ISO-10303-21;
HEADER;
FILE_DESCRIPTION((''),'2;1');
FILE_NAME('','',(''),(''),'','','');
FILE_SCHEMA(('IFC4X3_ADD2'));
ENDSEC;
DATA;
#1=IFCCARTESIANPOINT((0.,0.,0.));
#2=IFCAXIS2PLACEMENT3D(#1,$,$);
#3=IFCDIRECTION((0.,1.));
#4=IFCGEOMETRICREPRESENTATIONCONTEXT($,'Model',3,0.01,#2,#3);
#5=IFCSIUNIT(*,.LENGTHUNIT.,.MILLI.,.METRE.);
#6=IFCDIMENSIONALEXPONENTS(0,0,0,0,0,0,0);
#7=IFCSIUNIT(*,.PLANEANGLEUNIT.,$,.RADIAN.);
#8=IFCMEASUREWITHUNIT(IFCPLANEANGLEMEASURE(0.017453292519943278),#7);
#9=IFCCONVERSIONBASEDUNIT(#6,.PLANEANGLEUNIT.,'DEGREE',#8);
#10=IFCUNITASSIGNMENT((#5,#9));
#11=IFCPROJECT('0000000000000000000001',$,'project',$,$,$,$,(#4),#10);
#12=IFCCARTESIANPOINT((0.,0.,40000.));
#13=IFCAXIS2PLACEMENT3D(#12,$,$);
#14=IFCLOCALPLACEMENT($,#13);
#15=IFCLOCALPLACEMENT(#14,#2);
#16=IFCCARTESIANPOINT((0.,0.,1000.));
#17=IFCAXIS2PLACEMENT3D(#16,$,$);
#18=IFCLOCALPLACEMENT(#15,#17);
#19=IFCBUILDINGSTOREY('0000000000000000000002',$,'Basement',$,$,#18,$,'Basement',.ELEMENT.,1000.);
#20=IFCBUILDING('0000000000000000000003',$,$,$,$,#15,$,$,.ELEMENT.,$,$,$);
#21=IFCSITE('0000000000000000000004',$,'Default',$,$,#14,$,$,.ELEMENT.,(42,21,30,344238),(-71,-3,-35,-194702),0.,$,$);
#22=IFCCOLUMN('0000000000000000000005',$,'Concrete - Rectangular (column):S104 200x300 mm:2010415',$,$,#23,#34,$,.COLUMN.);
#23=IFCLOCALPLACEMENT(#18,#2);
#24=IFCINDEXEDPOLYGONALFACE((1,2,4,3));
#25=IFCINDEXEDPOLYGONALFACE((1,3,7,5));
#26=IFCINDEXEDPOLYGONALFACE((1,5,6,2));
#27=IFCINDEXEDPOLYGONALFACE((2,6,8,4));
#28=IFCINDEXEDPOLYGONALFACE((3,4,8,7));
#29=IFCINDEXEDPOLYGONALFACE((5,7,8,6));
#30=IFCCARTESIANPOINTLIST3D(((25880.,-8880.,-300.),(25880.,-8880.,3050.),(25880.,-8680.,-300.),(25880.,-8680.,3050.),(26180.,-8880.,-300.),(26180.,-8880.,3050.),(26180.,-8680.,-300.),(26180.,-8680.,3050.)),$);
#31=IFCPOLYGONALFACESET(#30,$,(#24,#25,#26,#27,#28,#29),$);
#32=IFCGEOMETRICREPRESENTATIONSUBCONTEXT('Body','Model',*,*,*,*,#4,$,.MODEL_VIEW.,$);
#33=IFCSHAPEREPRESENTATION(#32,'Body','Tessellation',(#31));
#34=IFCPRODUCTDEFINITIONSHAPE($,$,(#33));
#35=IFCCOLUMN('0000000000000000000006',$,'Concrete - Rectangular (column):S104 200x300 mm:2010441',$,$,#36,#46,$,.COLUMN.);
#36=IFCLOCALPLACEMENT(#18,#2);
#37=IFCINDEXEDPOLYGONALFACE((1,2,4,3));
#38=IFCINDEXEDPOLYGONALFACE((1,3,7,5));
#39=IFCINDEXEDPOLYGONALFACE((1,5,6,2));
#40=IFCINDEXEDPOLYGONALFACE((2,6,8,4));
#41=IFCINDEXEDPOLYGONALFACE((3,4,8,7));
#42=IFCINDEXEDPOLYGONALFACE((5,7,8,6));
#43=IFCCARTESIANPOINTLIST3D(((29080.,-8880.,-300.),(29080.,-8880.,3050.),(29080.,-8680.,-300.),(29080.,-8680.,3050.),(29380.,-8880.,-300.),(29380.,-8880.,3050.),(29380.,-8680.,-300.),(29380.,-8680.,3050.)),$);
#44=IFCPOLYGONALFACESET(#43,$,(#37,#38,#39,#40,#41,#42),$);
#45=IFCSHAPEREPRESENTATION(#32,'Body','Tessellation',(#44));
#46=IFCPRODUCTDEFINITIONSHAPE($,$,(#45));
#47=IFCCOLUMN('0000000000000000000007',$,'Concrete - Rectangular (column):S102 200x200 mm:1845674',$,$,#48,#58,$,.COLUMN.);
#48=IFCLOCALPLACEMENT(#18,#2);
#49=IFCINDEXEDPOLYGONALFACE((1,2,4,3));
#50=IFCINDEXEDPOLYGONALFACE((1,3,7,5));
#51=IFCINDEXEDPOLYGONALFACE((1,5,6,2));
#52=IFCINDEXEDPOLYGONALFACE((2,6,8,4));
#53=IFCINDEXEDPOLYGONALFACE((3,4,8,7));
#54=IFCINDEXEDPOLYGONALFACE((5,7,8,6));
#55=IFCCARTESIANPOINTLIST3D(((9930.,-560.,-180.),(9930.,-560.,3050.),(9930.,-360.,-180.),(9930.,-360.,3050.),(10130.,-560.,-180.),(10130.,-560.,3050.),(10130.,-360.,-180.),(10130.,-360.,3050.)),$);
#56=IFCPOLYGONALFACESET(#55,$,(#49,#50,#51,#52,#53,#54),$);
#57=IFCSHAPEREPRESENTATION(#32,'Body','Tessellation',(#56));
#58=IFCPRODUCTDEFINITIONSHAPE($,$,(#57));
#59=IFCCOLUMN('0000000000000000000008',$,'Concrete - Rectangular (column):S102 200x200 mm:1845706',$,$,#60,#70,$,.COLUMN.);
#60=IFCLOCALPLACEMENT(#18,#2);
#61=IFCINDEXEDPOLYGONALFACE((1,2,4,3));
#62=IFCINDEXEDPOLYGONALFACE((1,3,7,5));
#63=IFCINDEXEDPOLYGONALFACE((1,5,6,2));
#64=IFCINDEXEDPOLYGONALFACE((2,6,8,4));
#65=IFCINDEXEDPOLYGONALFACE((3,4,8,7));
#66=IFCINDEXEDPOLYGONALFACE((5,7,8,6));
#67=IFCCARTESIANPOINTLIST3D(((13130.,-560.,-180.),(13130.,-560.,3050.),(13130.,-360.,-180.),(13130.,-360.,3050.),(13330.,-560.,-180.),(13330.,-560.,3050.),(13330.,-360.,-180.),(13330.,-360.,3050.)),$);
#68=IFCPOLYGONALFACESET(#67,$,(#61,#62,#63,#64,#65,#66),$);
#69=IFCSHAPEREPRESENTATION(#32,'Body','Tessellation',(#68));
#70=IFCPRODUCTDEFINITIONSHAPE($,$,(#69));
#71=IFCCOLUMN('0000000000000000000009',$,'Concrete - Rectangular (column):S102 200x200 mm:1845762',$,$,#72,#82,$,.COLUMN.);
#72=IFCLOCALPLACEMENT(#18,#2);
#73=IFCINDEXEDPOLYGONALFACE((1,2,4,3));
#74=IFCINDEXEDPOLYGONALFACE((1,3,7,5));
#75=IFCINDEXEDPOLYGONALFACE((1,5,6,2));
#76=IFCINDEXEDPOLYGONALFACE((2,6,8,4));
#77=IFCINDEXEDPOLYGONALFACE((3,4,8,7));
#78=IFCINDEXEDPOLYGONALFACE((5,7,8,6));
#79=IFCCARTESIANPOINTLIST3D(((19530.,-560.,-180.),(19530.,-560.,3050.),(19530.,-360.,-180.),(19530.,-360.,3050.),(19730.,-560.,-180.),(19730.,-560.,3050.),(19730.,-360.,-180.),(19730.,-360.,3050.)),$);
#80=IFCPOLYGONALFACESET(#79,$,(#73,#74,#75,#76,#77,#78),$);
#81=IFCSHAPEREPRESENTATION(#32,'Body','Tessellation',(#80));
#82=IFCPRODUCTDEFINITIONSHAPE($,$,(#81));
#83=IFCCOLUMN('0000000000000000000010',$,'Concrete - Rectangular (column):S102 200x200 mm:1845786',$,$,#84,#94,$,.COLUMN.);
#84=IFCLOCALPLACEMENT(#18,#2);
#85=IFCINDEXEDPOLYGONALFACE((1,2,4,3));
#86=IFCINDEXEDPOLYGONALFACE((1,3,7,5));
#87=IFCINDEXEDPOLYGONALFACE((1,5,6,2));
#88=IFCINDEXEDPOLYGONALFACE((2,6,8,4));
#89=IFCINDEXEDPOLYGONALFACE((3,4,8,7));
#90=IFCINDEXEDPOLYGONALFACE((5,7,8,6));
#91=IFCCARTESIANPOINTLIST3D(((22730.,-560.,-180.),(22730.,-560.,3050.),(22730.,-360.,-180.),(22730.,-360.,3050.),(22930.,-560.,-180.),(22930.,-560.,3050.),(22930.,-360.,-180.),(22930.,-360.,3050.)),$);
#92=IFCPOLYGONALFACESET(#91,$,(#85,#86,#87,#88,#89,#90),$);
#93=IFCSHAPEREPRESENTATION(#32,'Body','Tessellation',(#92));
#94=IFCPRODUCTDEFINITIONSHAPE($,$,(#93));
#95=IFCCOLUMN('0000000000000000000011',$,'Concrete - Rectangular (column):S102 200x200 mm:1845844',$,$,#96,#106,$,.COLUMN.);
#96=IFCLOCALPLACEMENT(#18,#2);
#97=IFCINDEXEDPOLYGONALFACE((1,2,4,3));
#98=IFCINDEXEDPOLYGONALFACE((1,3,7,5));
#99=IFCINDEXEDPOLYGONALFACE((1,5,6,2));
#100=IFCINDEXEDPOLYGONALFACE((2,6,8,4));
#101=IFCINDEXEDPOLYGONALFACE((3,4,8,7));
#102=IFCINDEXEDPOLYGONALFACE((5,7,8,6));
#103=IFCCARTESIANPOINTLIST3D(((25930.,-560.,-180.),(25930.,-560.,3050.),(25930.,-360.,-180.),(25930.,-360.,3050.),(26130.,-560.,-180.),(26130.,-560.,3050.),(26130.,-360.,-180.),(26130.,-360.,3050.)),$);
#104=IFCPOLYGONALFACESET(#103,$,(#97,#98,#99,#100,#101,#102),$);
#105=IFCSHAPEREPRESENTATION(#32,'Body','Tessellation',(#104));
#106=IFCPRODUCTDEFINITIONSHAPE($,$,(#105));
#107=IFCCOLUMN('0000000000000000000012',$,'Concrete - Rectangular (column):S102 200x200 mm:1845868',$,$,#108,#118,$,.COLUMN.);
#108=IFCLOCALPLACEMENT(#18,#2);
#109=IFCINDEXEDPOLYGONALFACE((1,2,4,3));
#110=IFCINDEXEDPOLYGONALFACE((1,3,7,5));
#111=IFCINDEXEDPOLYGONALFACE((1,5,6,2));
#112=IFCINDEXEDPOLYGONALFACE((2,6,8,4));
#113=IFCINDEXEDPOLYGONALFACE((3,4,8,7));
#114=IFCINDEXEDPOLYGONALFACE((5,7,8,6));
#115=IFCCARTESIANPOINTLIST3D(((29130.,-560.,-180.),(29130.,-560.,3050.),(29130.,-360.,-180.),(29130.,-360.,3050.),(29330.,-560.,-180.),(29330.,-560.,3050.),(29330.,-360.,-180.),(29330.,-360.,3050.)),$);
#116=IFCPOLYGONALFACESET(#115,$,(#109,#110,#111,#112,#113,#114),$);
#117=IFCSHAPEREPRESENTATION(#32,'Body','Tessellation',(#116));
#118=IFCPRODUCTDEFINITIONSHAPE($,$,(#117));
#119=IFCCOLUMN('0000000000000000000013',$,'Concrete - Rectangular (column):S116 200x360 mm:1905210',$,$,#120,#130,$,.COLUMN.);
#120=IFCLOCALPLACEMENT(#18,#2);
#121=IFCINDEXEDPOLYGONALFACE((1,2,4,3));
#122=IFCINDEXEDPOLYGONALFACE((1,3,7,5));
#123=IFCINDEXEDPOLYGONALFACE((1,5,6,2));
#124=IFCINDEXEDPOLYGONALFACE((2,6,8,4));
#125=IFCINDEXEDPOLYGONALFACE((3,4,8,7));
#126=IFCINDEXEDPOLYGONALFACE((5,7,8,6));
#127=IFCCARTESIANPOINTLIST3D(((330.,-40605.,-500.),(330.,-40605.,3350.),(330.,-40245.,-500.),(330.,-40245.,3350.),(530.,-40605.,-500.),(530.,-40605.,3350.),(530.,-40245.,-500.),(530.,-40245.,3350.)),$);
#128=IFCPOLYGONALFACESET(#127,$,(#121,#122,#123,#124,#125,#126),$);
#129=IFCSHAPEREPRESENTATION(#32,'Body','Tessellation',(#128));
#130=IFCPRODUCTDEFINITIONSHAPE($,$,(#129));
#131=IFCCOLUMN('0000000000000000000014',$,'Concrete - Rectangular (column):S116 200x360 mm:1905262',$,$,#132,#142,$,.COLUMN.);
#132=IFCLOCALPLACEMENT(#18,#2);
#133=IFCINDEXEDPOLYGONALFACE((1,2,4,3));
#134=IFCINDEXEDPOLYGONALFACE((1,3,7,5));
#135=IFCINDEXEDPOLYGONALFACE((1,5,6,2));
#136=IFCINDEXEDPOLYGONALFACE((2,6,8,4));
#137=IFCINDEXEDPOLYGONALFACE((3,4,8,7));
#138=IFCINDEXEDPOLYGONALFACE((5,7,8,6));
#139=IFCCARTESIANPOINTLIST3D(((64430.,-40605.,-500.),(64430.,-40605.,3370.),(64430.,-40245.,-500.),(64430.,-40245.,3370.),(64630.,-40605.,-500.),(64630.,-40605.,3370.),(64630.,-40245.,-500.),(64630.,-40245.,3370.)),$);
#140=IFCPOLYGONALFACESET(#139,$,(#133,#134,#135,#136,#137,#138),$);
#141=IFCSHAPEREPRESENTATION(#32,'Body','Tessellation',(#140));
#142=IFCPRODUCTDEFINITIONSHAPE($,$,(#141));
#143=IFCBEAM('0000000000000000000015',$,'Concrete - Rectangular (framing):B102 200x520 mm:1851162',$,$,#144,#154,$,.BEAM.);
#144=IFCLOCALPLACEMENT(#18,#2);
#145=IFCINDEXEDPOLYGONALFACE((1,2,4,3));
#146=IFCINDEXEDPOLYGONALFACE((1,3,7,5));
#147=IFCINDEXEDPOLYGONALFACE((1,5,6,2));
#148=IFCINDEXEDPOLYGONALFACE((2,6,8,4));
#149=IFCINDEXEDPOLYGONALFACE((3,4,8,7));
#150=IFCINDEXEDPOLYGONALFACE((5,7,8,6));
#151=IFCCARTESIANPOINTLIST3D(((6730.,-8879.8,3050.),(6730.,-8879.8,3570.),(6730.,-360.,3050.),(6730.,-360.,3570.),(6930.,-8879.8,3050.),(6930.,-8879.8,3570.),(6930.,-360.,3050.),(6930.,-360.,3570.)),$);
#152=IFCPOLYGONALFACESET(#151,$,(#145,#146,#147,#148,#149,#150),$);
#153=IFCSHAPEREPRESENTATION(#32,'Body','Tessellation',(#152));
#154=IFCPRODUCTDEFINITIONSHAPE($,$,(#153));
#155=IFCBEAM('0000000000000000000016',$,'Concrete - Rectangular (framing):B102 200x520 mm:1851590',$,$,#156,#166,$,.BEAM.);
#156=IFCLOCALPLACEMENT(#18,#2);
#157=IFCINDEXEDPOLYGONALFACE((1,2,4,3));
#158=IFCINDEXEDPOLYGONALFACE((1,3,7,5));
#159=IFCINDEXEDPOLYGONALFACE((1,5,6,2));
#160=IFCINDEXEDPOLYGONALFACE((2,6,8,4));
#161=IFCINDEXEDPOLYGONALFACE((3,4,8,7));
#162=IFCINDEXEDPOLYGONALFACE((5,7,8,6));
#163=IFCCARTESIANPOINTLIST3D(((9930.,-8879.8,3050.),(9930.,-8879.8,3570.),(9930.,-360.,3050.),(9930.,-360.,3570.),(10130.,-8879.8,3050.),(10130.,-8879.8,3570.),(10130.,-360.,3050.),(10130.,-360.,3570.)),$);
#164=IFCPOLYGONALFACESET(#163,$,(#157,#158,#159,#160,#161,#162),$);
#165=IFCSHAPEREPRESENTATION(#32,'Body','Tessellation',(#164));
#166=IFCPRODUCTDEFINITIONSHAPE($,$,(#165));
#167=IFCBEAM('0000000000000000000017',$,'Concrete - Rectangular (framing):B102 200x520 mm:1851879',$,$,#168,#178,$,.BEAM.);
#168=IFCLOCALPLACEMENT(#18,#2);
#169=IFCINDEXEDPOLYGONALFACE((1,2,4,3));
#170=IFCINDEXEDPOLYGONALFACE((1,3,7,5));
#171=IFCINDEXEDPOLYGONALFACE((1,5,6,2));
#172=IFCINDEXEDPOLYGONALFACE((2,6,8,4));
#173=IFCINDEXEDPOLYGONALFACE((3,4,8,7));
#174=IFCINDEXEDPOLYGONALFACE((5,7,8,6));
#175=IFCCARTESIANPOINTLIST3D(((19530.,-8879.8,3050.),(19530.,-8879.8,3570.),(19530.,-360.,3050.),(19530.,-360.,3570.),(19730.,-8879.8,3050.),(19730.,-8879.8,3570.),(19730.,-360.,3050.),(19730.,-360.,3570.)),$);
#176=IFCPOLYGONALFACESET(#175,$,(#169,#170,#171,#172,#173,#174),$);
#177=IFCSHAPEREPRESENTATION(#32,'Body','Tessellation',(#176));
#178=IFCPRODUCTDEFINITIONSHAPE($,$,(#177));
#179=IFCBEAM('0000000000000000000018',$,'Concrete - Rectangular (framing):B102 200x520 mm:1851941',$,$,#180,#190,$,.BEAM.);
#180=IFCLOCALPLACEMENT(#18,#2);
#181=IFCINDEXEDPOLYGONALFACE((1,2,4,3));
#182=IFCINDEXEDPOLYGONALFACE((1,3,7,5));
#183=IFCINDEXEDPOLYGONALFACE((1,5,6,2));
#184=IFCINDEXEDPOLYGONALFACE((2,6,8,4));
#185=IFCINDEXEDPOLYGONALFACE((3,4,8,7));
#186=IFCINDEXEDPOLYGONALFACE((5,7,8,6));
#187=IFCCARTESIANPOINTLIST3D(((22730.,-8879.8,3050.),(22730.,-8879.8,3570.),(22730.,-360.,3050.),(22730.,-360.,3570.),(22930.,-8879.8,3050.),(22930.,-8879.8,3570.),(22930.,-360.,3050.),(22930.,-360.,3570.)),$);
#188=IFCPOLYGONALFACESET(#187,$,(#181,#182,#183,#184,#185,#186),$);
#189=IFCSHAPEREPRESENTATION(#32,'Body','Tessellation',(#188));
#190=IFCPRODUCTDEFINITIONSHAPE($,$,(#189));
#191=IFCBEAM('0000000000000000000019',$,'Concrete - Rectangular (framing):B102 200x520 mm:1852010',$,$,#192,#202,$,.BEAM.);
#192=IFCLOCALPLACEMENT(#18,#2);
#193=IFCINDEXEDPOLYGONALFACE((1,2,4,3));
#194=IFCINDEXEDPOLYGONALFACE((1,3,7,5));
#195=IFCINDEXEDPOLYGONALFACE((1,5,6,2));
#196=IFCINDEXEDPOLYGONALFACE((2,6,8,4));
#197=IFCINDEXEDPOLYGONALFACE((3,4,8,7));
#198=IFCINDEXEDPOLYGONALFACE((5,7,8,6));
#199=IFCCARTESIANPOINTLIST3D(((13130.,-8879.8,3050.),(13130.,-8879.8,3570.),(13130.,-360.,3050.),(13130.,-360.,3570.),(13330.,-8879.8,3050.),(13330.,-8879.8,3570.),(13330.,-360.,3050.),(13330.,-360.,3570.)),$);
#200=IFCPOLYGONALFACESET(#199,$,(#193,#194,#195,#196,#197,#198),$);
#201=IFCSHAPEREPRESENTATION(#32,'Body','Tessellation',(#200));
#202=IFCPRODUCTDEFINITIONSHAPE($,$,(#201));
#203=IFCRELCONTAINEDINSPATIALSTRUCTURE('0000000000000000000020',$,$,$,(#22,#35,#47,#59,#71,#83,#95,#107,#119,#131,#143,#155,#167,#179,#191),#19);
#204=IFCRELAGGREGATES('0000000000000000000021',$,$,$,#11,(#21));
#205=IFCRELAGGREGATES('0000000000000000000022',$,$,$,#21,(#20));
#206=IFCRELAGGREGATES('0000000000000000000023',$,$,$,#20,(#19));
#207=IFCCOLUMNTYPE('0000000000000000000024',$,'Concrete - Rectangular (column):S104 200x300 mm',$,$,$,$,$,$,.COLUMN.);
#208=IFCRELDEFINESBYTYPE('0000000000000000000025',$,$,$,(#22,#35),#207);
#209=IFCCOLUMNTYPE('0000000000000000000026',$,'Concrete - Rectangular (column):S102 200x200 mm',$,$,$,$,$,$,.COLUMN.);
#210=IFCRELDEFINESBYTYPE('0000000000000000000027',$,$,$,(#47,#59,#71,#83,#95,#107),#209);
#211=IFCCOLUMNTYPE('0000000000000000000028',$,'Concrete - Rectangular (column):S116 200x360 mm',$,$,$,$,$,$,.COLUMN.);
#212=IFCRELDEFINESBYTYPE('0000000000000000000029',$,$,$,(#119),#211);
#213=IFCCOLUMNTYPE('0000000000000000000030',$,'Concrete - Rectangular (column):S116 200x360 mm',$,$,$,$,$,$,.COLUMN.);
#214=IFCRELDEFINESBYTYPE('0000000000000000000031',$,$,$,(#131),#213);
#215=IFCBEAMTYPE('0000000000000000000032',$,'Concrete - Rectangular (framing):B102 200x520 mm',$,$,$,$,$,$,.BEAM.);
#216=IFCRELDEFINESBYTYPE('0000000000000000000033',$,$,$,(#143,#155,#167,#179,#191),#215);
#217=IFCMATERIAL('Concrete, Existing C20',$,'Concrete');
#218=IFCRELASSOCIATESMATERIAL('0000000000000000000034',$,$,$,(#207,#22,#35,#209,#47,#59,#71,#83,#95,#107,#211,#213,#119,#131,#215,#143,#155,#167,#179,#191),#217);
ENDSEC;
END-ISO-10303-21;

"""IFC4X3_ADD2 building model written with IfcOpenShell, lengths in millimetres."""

from ifc_helpers import new_model, entity, si_unit, converted_unit, direction, frame, frame_2d, origin, origin_2d_with_axis, place, context, subcontext, project, spatial, rectangle, extrude, source, transform, mapped, material, material_profile, profile_set, profile_usage, type_object, type_shapes, element, save


model = new_model("IFC4X3_ADD2")

# Units and contexts
model_context = context("Model", 3, precision=0.01, world=origin(), true_north=direction((0.0, 1.0)))
body_context = subcontext(model_context, "Body", "Model", "MODEL_VIEW")
ifc_project = project(units=[si_unit("LENGTHUNIT", "METRE", prefix="MILLI"), converted_unit("PLANEANGLEUNIT", "DEGREE", entity("IfcPlaneAngleMeasure", 0.017453292519943278), si_unit("PLANEANGLEUNIT", "RADIAN"), dimensions=[0, 0, 0, 0, 0, 0, 0])], contexts=[model_context])

# Site, building, storey
site_placement = place(None, frame((0.0, 0.0, 40000.0)))
site = spatial("IfcSite", under=ifc_project, at=site_placement, Name="Default", CompositionType="ELEMENT", RefLatitude=(42, 21, 30, 344238), RefLongitude=(-71, -3, -35, -194702), RefElevation=0.0)
building_placement = place(site_placement, origin())
building = spatial("IfcBuilding", under=site, at=building_placement, CompositionType="ELEMENT")
storey_placement = place(building_placement, frame((0.0, 0.0, 1000.0)))
storey = spatial("IfcBuildingStorey", under=building, at=storey_placement, Name="Basement", LongName="Basement", CompositionType="ELEMENT", Elevation=1000.0)

# Columns
ifc_material_1 = material(Name="Concrete, Existing C20", Category="Concrete")
ifc_material_profile_1 = material_profile(ifc_material_1, rectangle(XDim=200.0, YDim=300.0, at=frame_2d((0.0, 0.0), x_axis=(1.0, 0.0))), Name="S104 200x300 mm")
ifc_profile_set_1 = profile_set([ifc_material_profile_1], Name="S104 200x300 mm")
ifc_profile_usage_1 = profile_usage(ifc_profile_set_1)
column_type_1 = type_object("IfcColumnType", Name="Concrete - Rectangular (column):S104 200x300 mm", PredefinedType="COLUMN", material=ifc_profile_set_1)
shared_shape_1 = source(origin(), body_context, "Body", "SweptSolid", [
    extrude(rectangle(XDim=200.0, YDim=300.0, at=origin_2d_with_axis()), frame((0.0, 0.0, 700.0), z_axis=(0.0, 0.0, 1.0), x_axis=(-1.0, 0.0, 0.0)), (0.0, 0.0, 1.0), 3350.0),
])
type_shapes(column_type_1, [shared_shape_1])
for number, where, z_axis, x_axis, name in (
    (1, (26030.0, -8780.0, -1000.0), (0.0, 0.0, 1.0), (0.0, -1.0, 0.0), "Concrete - Rectangular (column):S104 200x300 mm:2010415"),
    (2, (29230.0, -8780.0, -1000.0), (0.0, 0.0, 1.0), (0.0, -1.0, 0.0), "Concrete - Rectangular (column):S104 200x300 mm:2010441"),
):
    element("IfcColumn", number, at=place(storey_placement, frame(where, z_axis=z_axis, x_axis=x_axis)), inside=storey, type_object=column_type_1, material=ifc_profile_usage_1, Name=name, PredefinedType="COLUMN", context=body_context, shape_type="MappedRepresentation", body=[
        mapped(shared_shape_1, transform((0.0, 0.0, 0.0), scale=1.0)),
    ])
ifc_material_profile_2 = material_profile(ifc_material_1, rectangle(XDim=200.0, YDim=200.0, at=frame_2d((0.0, 0.0), x_axis=(1.0, 0.0))), Name="S102 200x200 mm")
ifc_profile_set_2 = profile_set([ifc_material_profile_2], Name="S102 200x200 mm")
ifc_profile_usage_2 = profile_usage(ifc_profile_set_2)
column_type_2 = type_object("IfcColumnType", Name="Concrete - Rectangular (column):S102 200x200 mm", PredefinedType="COLUMN", material=ifc_profile_set_2)
shared_shape_2 = source(origin(), body_context, "Body", "SweptSolid", [
    extrude(rectangle(XDim=200.0, YDim=200.0, at=origin_2d_with_axis()), frame((0.0, 0.0, 820.0), z_axis=(0.0, 0.0, 1.0), x_axis=(-1.0, 0.0, 0.0)), (0.0, 0.0, 1.0), 3230.0),
])
type_shapes(column_type_2, [shared_shape_2])
for number, where, z_axis, x_axis, name in (
    (3, (10030.0, -460.0, -1000.0), (0.0, 0.0, 1.0), (0.0, -1.0, 0.0), "Concrete - Rectangular (column):S102 200x200 mm:1845674"),
    (4, (13230.0, -460.0, -1000.0), (0.0, 0.0, 1.0), (0.0, -1.0, 0.0), "Concrete - Rectangular (column):S102 200x200 mm:1845706"),
    (5, (19630.0, -460.0, -1000.0), (0.0, 0.0, 1.0), (0.0, -1.0, 0.0), "Concrete - Rectangular (column):S102 200x200 mm:1845762"),
    (6, (22830.0, -460.0, -1000.0), (0.0, 0.0, 1.0), (0.0, -1.0, 0.0), "Concrete - Rectangular (column):S102 200x200 mm:1845786"),
    (7, (26030.0, -460.0, -1000.0), (0.0, 0.0, 1.0), (0.0, -1.0, 0.0), "Concrete - Rectangular (column):S102 200x200 mm:1845844"),
    (8, (29230.0, -460.0, -1000.0), (0.0, 0.0, 1.0), (0.0, -1.0, 0.0), "Concrete - Rectangular (column):S102 200x200 mm:1845868"),
):
    element("IfcColumn", number, at=place(storey_placement, frame(where, z_axis=z_axis, x_axis=x_axis)), inside=storey, type_object=column_type_2, material=ifc_profile_usage_2, Name=name, PredefinedType="COLUMN", context=body_context, shape_type="MappedRepresentation", body=[
        mapped(shared_shape_2, transform((0.0, 0.0, 0.0), scale=1.0)),
    ])
ifc_material_profile_3 = material_profile(ifc_material_1, rectangle(XDim=360.0, YDim=200.0, at=origin_2d_with_axis()), Name="S116 200x360 mm")
ifc_profile_set_3 = profile_set([ifc_material_profile_3], Name="S116 200x360 mm")
ifc_profile_usage_3 = profile_usage(ifc_profile_set_3)
column_type_3 = type_object("IfcColumnType", Name="Concrete - Rectangular (column):S116 200x360 mm", PredefinedType="COLUMN", material=ifc_profile_set_3)
shared_shape_3 = source(origin(), body_context, "Body", "SweptSolid", [
    extrude(rectangle(XDim=360.0, YDim=200.0, at=frame_2d((0.0, 0.0), x_axis=(1.0, 0.0))), frame((430.0, -40425.0, 500.0), z_axis=(0.0, 0.0, 1.0), x_axis=(0.0, -1.0, 0.0)), (0.0, 0.0, 1.0), 3850.0),
])
type_shapes(column_type_3, [shared_shape_3])
column_1_placement = place(storey_placement, frame((0.0, 0.0, -1000.0)))
element("IfcColumn", 9, at=column_1_placement, inside=storey, type_object=column_type_3, material=ifc_profile_usage_3, Name="Concrete - Rectangular (column):S116 200x360 mm:1905210", PredefinedType="COLUMN", context=body_context, shape_type="MappedRepresentation", body=[
    mapped(shared_shape_3, transform((0.0, 0.0, 0.0), scale=1.0)),
])
column_type_4 = type_object("IfcColumnType", Name="Concrete - Rectangular (column):S116 200x360 mm", PredefinedType="COLUMN", material=ifc_profile_set_3)
shared_shape_4 = source(origin(), body_context, "Body", "SweptSolid", [
    extrude(rectangle(XDim=360.0, YDim=200.0, at=frame_2d((0.0, 0.0), x_axis=(1.0, 0.0))), frame((64530.0, -40425.0, 500.0), z_axis=(0.0, 0.0, 1.0), x_axis=(0.0, 1.0, 0.0)), (0.0, 0.0, 1.0), 3870.0),
])
type_shapes(column_type_4, [shared_shape_4])
column_2_placement = place(storey_placement, frame((0.0, 0.0, -1000.0)))
element("IfcColumn", 10, at=column_2_placement, inside=storey, type_object=column_type_4, material=ifc_profile_usage_3, Name="Concrete - Rectangular (column):S116 200x360 mm:1905262", PredefinedType="COLUMN", context=body_context, shape_type="MappedRepresentation", body=[
    mapped(shared_shape_4, transform((0.0, 0.0, 0.0), scale=1.0)),
])

# Beams
ifc_material_profile_4 = material_profile(ifc_material_1, rectangle(XDim=8519.8, YDim=200.0, at=origin_2d_with_axis()), Name="B102 200x520 mm")
ifc_profile_set_4 = profile_set([ifc_material_profile_4], Name="B102 200x520 mm")
ifc_profile_usage_4 = profile_usage(ifc_profile_set_4, cardinal=8)
beam_type_1 = type_object("IfcBeamType", Name="Concrete - Rectangular (framing):B102 200x520 mm", PredefinedType="BEAM", material=ifc_profile_set_4)
shared_shape_5 = source(origin(), body_context, "Body", "SweptSolid", [
    extrude(rectangle(XDim=8519.8, YDim=200.0, at=origin_2d_with_axis()), frame((-0.1, 0.0, -260.0), z_axis=(0.0, 0.0, 1.0), x_axis=(-1.0, 0.0, 0.0)), (0.0, 0.0, 1.0), 520.0),
])
type_shapes(beam_type_1, [shared_shape_5])
for number, where, z_axis, x_axis, name in (
    (11, (6830.0, -4620.0, 3310.0), (0.0, 0.0, 1.0), (0.0, -1.0, 0.0), "Concrete - Rectangular (framing):B102 200x520 mm:1851162"),
    (12, (10030.0, -4620.0, 3310.0), (0.0, 0.0, 1.0), (0.0, -1.0, 0.0), "Concrete - Rectangular (framing):B102 200x520 mm:1851590"),
    (13, (19630.0, -4620.0, 3310.0), (0.0, 0.0, 1.0), (0.0, -1.0, 0.0), "Concrete - Rectangular (framing):B102 200x520 mm:1851879"),
    (14, (22830.0, -4620.0, 3310.0), (0.0, 0.0, 1.0), (0.0, -1.0, 0.0), "Concrete - Rectangular (framing):B102 200x520 mm:1851941"),
    (15, (13230.0, -4620.0, 3310.0), (0.0, 0.0, 1.0), (0.0, -1.0, 0.0), "Concrete - Rectangular (framing):B102 200x520 mm:1852010"),
):
    element("IfcBeam", number, at=place(storey_placement, frame(where, z_axis=z_axis, x_axis=x_axis)), inside=storey, type_object=beam_type_1, material=ifc_profile_usage_4, Name=name, PredefinedType="BEAM", context=body_context, shape_type="MappedRepresentation", body=[
        mapped(shared_shape_5, transform((0.0, 0.0, 0.0), scale=1.0)),
    ])

save(model, "model.ifc")
